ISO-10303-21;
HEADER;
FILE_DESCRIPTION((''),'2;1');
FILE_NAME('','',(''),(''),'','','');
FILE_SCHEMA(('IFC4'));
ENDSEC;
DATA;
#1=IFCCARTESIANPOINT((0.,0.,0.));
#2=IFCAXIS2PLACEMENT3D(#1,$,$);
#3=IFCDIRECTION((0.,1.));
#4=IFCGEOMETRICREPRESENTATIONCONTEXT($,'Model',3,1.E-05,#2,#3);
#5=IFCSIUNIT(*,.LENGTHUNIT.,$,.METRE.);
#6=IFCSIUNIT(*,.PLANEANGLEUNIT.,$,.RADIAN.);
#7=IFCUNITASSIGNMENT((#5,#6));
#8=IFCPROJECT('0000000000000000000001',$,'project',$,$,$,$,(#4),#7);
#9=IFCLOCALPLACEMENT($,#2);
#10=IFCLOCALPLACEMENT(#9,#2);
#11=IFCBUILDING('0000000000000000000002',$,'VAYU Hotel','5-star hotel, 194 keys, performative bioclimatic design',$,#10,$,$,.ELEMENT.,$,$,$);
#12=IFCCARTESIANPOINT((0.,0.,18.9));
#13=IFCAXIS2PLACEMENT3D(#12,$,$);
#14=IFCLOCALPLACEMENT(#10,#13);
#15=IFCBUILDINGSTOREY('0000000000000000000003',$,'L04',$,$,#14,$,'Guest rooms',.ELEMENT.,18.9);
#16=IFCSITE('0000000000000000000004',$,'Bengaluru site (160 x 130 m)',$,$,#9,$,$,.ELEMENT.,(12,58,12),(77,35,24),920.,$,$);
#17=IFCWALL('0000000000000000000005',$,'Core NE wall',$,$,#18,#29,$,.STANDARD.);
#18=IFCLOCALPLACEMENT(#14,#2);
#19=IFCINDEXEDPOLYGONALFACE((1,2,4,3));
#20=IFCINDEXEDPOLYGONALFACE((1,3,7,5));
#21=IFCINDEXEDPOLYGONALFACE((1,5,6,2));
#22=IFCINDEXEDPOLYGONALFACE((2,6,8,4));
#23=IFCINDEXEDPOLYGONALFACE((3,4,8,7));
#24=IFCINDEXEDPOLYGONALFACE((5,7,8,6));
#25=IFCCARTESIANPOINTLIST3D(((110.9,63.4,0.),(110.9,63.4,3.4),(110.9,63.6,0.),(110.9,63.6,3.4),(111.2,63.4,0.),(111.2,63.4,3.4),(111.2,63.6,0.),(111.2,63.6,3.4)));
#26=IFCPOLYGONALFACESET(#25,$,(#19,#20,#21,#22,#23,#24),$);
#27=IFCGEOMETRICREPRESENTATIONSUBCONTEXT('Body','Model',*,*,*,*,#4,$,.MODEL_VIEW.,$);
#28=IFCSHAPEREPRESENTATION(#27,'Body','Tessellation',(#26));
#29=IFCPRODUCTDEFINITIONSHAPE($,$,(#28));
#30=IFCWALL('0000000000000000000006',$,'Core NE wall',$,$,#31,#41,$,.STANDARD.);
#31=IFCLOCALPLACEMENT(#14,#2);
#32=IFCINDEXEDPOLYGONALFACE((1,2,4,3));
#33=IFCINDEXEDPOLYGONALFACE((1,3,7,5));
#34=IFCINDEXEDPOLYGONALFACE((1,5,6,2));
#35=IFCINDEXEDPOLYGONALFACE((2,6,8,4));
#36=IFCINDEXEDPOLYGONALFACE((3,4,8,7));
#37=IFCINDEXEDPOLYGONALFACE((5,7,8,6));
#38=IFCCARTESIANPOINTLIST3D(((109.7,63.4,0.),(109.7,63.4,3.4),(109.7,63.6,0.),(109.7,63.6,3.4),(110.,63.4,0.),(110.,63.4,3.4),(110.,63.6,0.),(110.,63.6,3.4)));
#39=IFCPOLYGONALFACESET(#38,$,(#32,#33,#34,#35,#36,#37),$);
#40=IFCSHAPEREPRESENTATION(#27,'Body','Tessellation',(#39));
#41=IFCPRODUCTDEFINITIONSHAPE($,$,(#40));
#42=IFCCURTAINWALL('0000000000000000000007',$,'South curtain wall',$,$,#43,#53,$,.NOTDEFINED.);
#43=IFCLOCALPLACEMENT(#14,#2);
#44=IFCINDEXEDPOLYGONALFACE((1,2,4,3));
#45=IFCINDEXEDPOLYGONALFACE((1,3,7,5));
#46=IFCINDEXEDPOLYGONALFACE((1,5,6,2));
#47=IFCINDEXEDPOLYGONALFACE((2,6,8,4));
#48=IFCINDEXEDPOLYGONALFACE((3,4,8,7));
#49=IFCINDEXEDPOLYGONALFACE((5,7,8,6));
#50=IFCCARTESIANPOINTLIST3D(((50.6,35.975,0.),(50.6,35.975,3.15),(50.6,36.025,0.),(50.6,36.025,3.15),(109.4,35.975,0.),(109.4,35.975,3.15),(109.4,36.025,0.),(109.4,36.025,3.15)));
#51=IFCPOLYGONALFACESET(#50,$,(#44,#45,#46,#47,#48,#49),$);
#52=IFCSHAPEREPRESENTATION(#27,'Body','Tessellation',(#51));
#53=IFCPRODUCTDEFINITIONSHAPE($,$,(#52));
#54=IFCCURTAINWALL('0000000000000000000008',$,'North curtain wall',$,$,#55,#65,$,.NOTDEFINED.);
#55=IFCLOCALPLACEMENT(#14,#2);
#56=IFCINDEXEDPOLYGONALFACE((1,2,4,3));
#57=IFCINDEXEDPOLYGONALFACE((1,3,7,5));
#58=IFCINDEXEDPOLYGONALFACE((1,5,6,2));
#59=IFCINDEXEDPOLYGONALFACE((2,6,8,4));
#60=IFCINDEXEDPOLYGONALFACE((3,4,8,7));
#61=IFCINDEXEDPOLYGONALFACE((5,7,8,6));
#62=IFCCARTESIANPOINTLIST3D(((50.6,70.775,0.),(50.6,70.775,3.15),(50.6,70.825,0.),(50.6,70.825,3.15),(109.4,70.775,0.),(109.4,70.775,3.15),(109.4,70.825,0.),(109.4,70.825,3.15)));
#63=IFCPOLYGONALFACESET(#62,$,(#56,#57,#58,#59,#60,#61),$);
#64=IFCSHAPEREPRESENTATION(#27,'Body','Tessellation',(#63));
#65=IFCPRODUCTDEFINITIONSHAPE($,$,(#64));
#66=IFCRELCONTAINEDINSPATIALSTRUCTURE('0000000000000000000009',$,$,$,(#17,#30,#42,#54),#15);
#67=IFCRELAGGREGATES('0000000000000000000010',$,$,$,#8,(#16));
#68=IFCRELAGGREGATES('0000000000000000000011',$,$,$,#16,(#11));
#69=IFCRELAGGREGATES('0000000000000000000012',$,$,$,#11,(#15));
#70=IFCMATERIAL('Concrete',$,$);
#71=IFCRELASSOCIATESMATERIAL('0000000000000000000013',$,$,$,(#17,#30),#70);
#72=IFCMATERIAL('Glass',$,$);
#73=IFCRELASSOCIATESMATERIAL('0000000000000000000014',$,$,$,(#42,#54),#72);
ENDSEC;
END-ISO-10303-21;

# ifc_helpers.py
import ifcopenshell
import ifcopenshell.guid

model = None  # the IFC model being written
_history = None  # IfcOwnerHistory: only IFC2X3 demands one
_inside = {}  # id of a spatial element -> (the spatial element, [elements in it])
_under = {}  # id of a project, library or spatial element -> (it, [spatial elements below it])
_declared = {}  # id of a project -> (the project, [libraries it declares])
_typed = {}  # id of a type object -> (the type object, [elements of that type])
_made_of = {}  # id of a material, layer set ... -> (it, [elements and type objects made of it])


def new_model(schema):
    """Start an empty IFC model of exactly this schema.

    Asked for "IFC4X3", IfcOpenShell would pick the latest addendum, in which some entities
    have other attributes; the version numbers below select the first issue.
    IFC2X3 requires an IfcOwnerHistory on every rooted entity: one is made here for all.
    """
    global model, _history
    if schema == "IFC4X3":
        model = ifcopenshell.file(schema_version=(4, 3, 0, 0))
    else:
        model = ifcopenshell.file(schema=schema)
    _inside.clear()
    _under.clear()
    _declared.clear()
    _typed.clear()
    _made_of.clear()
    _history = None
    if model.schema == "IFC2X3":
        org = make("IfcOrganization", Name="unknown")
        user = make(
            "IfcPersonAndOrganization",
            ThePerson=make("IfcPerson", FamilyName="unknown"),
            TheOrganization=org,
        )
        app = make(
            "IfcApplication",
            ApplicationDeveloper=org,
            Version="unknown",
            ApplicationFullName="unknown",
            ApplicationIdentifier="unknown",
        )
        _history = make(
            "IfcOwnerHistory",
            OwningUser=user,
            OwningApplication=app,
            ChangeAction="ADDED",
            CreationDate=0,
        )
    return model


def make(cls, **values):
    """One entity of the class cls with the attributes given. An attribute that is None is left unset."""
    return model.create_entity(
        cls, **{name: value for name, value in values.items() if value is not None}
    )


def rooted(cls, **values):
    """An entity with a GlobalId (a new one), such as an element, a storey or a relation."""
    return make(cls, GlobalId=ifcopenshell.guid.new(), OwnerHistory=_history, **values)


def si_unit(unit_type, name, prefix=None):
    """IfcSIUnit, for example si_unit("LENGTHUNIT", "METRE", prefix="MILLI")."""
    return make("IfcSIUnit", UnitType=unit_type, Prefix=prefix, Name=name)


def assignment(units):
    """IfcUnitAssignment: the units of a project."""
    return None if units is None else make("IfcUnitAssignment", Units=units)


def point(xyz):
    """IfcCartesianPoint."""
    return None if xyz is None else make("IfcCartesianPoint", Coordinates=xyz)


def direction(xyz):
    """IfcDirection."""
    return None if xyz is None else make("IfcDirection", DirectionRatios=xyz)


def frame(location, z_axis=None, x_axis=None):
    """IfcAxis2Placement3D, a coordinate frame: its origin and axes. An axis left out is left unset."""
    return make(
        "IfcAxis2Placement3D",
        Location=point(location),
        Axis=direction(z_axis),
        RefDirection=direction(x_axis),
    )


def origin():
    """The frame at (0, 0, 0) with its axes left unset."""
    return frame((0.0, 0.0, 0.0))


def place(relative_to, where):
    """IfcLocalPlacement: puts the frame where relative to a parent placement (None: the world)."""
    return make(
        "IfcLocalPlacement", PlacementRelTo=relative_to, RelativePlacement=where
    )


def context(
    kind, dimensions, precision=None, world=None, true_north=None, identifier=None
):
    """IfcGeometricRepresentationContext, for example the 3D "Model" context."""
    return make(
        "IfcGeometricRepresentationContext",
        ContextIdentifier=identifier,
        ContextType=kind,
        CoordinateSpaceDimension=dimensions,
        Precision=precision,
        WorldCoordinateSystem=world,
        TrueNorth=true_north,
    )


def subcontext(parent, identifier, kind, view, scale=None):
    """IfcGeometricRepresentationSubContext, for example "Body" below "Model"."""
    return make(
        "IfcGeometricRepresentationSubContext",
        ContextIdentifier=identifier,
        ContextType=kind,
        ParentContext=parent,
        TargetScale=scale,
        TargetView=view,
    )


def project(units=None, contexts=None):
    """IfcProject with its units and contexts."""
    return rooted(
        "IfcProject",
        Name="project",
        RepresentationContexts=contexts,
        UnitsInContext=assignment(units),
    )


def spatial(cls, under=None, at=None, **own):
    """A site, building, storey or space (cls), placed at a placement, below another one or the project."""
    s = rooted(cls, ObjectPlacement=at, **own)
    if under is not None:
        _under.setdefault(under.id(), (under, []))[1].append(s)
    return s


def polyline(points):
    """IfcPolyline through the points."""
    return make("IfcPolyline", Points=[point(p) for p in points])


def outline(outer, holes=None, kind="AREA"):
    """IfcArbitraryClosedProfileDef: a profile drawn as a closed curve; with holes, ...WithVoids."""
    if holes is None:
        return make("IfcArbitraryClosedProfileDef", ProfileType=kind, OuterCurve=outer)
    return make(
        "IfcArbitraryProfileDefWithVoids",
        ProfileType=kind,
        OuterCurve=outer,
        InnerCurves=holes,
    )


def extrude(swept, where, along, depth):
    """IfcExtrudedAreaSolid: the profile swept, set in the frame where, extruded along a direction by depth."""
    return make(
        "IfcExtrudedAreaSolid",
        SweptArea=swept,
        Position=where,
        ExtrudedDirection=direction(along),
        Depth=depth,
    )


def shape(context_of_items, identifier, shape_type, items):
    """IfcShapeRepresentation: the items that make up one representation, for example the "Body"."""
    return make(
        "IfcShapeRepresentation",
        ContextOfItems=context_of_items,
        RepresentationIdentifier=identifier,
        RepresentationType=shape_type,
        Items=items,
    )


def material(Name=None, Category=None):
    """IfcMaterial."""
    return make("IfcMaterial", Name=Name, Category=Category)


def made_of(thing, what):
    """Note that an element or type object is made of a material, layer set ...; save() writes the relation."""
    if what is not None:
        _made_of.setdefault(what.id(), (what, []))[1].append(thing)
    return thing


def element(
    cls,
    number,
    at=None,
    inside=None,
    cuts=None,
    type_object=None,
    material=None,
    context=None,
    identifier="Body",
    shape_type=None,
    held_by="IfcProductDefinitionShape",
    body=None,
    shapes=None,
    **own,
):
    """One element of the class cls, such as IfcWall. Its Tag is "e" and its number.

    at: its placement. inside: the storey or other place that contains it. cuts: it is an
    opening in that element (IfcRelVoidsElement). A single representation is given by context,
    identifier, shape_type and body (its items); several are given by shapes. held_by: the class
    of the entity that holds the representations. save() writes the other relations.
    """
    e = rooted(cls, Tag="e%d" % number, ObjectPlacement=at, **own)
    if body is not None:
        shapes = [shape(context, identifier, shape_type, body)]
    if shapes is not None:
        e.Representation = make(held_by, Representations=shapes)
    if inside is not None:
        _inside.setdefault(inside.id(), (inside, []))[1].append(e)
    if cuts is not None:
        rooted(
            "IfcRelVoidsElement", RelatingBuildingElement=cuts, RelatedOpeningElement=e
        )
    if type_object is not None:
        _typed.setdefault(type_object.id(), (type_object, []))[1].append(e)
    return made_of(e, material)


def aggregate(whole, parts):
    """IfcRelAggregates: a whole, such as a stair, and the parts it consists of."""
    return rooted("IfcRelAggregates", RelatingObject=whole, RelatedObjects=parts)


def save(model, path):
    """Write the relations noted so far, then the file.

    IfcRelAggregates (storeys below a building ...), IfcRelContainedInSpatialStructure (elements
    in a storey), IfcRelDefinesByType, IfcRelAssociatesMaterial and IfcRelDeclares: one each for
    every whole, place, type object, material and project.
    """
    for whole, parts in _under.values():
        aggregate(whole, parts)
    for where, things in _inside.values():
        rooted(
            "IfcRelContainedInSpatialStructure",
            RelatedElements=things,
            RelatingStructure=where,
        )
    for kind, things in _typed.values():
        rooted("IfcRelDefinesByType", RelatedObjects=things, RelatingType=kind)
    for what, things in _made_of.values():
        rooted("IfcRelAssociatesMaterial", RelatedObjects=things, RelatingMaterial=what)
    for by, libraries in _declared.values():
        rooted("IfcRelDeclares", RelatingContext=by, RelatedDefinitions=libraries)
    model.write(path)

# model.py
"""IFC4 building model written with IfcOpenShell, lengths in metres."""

from ifc_helpers import new_model, si_unit, direction, frame, origin, place, context, subcontext, project, spatial, polyline, outline, extrude, material, element, save


model = new_model("IFC4")

# Units and contexts
model_context = context("Model", 3, precision=1e-05, world=origin(), true_north=direction((0.0, 1.0)))
body_context = subcontext(model_context, "Body", "Model", "MODEL_VIEW")
ifc_project = project(units=[si_unit("LENGTHUNIT", "METRE"), si_unit("PLANEANGLEUNIT", "RADIAN")], contexts=[model_context])

# Site, building, storey
site_placement = place(None, origin())
site = spatial("IfcSite", under=ifc_project, at=site_placement, Name="Bengaluru site (160 x 130 m)", CompositionType="ELEMENT", RefLatitude=(12, 58, 12), RefLongitude=(77, 35, 24), RefElevation=920.0)
building_placement = place(site_placement, origin())
building = spatial("IfcBuilding", under=site, at=building_placement, Name="VAYU Hotel", Description="5-star hotel, 194 keys, performative bioclimatic design", CompositionType="ELEMENT")
storey_placement = place(building_placement, frame((0.0, 0.0, 18.9)))
storey = spatial("IfcBuildingStorey", under=building, at=storey_placement, Name="L04", LongName="Guest rooms", CompositionType="ELEMENT", Elevation=18.9)

# Shared definitions
ifc_material_1 = material(Name="Concrete")

# Walls
wall_1_placement = place(storey_placement, origin())
element("IfcWall", 1, at=wall_1_placement, inside=storey, material=ifc_material_1, Name="Core NE wall", PredefinedType="STANDARD", context=body_context, shape_type="SweptSolid", body=[
    extrude(outline(polyline([(110.9, 63.6), (111.2, 63.6), (111.2, 63.4), (110.9, 63.4), (110.9, 63.6)])), origin(), (0.0, 0.0, 1.0), 3.4),
])
wall_2_placement = place(storey_placement, origin())
element("IfcWall", 2, at=wall_2_placement, inside=storey, material=ifc_material_1, Name="Core NE wall", PredefinedType="STANDARD", context=body_context, shape_type="SweptSolid", body=[
    extrude(outline(polyline([(109.7, 63.6), (110.0, 63.6), (110.0, 63.4), (109.7, 63.4), (109.7, 63.6)])), origin(), (0.0, 0.0, 1.0), 3.4),
])

# Curtain walls
ifc_material_2 = material(Name="Glass")
curtain_wall_1_placement = place(storey_placement, origin())
element("IfcCurtainWall", 3, at=curtain_wall_1_placement, inside=storey, material=ifc_material_2, Name="South curtain wall", PredefinedType="NOTDEFINED", context=body_context, shape_type="SweptSolid", body=[
    extrude(outline(polyline([(50.6, 36.025), (109.4, 36.025), (109.4, 35.975), (50.6, 35.975), (50.6, 36.025)])), origin(), (0.0, 0.0, 1.0), 3.15),
])
curtain_wall_2_placement = place(storey_placement, origin())
element("IfcCurtainWall", 4, at=curtain_wall_2_placement, inside=storey, material=ifc_material_2, Name="North curtain wall", PredefinedType="NOTDEFINED", context=body_context, shape_type="SweptSolid", body=[
    extrude(outline(polyline([(50.6, 70.825), (109.4, 70.825), (109.4, 70.775), (50.6, 70.775), (50.6, 70.825)])), origin(), (0.0, 0.0, 1.0), 3.15),
])

save(model, "model.ifc")
